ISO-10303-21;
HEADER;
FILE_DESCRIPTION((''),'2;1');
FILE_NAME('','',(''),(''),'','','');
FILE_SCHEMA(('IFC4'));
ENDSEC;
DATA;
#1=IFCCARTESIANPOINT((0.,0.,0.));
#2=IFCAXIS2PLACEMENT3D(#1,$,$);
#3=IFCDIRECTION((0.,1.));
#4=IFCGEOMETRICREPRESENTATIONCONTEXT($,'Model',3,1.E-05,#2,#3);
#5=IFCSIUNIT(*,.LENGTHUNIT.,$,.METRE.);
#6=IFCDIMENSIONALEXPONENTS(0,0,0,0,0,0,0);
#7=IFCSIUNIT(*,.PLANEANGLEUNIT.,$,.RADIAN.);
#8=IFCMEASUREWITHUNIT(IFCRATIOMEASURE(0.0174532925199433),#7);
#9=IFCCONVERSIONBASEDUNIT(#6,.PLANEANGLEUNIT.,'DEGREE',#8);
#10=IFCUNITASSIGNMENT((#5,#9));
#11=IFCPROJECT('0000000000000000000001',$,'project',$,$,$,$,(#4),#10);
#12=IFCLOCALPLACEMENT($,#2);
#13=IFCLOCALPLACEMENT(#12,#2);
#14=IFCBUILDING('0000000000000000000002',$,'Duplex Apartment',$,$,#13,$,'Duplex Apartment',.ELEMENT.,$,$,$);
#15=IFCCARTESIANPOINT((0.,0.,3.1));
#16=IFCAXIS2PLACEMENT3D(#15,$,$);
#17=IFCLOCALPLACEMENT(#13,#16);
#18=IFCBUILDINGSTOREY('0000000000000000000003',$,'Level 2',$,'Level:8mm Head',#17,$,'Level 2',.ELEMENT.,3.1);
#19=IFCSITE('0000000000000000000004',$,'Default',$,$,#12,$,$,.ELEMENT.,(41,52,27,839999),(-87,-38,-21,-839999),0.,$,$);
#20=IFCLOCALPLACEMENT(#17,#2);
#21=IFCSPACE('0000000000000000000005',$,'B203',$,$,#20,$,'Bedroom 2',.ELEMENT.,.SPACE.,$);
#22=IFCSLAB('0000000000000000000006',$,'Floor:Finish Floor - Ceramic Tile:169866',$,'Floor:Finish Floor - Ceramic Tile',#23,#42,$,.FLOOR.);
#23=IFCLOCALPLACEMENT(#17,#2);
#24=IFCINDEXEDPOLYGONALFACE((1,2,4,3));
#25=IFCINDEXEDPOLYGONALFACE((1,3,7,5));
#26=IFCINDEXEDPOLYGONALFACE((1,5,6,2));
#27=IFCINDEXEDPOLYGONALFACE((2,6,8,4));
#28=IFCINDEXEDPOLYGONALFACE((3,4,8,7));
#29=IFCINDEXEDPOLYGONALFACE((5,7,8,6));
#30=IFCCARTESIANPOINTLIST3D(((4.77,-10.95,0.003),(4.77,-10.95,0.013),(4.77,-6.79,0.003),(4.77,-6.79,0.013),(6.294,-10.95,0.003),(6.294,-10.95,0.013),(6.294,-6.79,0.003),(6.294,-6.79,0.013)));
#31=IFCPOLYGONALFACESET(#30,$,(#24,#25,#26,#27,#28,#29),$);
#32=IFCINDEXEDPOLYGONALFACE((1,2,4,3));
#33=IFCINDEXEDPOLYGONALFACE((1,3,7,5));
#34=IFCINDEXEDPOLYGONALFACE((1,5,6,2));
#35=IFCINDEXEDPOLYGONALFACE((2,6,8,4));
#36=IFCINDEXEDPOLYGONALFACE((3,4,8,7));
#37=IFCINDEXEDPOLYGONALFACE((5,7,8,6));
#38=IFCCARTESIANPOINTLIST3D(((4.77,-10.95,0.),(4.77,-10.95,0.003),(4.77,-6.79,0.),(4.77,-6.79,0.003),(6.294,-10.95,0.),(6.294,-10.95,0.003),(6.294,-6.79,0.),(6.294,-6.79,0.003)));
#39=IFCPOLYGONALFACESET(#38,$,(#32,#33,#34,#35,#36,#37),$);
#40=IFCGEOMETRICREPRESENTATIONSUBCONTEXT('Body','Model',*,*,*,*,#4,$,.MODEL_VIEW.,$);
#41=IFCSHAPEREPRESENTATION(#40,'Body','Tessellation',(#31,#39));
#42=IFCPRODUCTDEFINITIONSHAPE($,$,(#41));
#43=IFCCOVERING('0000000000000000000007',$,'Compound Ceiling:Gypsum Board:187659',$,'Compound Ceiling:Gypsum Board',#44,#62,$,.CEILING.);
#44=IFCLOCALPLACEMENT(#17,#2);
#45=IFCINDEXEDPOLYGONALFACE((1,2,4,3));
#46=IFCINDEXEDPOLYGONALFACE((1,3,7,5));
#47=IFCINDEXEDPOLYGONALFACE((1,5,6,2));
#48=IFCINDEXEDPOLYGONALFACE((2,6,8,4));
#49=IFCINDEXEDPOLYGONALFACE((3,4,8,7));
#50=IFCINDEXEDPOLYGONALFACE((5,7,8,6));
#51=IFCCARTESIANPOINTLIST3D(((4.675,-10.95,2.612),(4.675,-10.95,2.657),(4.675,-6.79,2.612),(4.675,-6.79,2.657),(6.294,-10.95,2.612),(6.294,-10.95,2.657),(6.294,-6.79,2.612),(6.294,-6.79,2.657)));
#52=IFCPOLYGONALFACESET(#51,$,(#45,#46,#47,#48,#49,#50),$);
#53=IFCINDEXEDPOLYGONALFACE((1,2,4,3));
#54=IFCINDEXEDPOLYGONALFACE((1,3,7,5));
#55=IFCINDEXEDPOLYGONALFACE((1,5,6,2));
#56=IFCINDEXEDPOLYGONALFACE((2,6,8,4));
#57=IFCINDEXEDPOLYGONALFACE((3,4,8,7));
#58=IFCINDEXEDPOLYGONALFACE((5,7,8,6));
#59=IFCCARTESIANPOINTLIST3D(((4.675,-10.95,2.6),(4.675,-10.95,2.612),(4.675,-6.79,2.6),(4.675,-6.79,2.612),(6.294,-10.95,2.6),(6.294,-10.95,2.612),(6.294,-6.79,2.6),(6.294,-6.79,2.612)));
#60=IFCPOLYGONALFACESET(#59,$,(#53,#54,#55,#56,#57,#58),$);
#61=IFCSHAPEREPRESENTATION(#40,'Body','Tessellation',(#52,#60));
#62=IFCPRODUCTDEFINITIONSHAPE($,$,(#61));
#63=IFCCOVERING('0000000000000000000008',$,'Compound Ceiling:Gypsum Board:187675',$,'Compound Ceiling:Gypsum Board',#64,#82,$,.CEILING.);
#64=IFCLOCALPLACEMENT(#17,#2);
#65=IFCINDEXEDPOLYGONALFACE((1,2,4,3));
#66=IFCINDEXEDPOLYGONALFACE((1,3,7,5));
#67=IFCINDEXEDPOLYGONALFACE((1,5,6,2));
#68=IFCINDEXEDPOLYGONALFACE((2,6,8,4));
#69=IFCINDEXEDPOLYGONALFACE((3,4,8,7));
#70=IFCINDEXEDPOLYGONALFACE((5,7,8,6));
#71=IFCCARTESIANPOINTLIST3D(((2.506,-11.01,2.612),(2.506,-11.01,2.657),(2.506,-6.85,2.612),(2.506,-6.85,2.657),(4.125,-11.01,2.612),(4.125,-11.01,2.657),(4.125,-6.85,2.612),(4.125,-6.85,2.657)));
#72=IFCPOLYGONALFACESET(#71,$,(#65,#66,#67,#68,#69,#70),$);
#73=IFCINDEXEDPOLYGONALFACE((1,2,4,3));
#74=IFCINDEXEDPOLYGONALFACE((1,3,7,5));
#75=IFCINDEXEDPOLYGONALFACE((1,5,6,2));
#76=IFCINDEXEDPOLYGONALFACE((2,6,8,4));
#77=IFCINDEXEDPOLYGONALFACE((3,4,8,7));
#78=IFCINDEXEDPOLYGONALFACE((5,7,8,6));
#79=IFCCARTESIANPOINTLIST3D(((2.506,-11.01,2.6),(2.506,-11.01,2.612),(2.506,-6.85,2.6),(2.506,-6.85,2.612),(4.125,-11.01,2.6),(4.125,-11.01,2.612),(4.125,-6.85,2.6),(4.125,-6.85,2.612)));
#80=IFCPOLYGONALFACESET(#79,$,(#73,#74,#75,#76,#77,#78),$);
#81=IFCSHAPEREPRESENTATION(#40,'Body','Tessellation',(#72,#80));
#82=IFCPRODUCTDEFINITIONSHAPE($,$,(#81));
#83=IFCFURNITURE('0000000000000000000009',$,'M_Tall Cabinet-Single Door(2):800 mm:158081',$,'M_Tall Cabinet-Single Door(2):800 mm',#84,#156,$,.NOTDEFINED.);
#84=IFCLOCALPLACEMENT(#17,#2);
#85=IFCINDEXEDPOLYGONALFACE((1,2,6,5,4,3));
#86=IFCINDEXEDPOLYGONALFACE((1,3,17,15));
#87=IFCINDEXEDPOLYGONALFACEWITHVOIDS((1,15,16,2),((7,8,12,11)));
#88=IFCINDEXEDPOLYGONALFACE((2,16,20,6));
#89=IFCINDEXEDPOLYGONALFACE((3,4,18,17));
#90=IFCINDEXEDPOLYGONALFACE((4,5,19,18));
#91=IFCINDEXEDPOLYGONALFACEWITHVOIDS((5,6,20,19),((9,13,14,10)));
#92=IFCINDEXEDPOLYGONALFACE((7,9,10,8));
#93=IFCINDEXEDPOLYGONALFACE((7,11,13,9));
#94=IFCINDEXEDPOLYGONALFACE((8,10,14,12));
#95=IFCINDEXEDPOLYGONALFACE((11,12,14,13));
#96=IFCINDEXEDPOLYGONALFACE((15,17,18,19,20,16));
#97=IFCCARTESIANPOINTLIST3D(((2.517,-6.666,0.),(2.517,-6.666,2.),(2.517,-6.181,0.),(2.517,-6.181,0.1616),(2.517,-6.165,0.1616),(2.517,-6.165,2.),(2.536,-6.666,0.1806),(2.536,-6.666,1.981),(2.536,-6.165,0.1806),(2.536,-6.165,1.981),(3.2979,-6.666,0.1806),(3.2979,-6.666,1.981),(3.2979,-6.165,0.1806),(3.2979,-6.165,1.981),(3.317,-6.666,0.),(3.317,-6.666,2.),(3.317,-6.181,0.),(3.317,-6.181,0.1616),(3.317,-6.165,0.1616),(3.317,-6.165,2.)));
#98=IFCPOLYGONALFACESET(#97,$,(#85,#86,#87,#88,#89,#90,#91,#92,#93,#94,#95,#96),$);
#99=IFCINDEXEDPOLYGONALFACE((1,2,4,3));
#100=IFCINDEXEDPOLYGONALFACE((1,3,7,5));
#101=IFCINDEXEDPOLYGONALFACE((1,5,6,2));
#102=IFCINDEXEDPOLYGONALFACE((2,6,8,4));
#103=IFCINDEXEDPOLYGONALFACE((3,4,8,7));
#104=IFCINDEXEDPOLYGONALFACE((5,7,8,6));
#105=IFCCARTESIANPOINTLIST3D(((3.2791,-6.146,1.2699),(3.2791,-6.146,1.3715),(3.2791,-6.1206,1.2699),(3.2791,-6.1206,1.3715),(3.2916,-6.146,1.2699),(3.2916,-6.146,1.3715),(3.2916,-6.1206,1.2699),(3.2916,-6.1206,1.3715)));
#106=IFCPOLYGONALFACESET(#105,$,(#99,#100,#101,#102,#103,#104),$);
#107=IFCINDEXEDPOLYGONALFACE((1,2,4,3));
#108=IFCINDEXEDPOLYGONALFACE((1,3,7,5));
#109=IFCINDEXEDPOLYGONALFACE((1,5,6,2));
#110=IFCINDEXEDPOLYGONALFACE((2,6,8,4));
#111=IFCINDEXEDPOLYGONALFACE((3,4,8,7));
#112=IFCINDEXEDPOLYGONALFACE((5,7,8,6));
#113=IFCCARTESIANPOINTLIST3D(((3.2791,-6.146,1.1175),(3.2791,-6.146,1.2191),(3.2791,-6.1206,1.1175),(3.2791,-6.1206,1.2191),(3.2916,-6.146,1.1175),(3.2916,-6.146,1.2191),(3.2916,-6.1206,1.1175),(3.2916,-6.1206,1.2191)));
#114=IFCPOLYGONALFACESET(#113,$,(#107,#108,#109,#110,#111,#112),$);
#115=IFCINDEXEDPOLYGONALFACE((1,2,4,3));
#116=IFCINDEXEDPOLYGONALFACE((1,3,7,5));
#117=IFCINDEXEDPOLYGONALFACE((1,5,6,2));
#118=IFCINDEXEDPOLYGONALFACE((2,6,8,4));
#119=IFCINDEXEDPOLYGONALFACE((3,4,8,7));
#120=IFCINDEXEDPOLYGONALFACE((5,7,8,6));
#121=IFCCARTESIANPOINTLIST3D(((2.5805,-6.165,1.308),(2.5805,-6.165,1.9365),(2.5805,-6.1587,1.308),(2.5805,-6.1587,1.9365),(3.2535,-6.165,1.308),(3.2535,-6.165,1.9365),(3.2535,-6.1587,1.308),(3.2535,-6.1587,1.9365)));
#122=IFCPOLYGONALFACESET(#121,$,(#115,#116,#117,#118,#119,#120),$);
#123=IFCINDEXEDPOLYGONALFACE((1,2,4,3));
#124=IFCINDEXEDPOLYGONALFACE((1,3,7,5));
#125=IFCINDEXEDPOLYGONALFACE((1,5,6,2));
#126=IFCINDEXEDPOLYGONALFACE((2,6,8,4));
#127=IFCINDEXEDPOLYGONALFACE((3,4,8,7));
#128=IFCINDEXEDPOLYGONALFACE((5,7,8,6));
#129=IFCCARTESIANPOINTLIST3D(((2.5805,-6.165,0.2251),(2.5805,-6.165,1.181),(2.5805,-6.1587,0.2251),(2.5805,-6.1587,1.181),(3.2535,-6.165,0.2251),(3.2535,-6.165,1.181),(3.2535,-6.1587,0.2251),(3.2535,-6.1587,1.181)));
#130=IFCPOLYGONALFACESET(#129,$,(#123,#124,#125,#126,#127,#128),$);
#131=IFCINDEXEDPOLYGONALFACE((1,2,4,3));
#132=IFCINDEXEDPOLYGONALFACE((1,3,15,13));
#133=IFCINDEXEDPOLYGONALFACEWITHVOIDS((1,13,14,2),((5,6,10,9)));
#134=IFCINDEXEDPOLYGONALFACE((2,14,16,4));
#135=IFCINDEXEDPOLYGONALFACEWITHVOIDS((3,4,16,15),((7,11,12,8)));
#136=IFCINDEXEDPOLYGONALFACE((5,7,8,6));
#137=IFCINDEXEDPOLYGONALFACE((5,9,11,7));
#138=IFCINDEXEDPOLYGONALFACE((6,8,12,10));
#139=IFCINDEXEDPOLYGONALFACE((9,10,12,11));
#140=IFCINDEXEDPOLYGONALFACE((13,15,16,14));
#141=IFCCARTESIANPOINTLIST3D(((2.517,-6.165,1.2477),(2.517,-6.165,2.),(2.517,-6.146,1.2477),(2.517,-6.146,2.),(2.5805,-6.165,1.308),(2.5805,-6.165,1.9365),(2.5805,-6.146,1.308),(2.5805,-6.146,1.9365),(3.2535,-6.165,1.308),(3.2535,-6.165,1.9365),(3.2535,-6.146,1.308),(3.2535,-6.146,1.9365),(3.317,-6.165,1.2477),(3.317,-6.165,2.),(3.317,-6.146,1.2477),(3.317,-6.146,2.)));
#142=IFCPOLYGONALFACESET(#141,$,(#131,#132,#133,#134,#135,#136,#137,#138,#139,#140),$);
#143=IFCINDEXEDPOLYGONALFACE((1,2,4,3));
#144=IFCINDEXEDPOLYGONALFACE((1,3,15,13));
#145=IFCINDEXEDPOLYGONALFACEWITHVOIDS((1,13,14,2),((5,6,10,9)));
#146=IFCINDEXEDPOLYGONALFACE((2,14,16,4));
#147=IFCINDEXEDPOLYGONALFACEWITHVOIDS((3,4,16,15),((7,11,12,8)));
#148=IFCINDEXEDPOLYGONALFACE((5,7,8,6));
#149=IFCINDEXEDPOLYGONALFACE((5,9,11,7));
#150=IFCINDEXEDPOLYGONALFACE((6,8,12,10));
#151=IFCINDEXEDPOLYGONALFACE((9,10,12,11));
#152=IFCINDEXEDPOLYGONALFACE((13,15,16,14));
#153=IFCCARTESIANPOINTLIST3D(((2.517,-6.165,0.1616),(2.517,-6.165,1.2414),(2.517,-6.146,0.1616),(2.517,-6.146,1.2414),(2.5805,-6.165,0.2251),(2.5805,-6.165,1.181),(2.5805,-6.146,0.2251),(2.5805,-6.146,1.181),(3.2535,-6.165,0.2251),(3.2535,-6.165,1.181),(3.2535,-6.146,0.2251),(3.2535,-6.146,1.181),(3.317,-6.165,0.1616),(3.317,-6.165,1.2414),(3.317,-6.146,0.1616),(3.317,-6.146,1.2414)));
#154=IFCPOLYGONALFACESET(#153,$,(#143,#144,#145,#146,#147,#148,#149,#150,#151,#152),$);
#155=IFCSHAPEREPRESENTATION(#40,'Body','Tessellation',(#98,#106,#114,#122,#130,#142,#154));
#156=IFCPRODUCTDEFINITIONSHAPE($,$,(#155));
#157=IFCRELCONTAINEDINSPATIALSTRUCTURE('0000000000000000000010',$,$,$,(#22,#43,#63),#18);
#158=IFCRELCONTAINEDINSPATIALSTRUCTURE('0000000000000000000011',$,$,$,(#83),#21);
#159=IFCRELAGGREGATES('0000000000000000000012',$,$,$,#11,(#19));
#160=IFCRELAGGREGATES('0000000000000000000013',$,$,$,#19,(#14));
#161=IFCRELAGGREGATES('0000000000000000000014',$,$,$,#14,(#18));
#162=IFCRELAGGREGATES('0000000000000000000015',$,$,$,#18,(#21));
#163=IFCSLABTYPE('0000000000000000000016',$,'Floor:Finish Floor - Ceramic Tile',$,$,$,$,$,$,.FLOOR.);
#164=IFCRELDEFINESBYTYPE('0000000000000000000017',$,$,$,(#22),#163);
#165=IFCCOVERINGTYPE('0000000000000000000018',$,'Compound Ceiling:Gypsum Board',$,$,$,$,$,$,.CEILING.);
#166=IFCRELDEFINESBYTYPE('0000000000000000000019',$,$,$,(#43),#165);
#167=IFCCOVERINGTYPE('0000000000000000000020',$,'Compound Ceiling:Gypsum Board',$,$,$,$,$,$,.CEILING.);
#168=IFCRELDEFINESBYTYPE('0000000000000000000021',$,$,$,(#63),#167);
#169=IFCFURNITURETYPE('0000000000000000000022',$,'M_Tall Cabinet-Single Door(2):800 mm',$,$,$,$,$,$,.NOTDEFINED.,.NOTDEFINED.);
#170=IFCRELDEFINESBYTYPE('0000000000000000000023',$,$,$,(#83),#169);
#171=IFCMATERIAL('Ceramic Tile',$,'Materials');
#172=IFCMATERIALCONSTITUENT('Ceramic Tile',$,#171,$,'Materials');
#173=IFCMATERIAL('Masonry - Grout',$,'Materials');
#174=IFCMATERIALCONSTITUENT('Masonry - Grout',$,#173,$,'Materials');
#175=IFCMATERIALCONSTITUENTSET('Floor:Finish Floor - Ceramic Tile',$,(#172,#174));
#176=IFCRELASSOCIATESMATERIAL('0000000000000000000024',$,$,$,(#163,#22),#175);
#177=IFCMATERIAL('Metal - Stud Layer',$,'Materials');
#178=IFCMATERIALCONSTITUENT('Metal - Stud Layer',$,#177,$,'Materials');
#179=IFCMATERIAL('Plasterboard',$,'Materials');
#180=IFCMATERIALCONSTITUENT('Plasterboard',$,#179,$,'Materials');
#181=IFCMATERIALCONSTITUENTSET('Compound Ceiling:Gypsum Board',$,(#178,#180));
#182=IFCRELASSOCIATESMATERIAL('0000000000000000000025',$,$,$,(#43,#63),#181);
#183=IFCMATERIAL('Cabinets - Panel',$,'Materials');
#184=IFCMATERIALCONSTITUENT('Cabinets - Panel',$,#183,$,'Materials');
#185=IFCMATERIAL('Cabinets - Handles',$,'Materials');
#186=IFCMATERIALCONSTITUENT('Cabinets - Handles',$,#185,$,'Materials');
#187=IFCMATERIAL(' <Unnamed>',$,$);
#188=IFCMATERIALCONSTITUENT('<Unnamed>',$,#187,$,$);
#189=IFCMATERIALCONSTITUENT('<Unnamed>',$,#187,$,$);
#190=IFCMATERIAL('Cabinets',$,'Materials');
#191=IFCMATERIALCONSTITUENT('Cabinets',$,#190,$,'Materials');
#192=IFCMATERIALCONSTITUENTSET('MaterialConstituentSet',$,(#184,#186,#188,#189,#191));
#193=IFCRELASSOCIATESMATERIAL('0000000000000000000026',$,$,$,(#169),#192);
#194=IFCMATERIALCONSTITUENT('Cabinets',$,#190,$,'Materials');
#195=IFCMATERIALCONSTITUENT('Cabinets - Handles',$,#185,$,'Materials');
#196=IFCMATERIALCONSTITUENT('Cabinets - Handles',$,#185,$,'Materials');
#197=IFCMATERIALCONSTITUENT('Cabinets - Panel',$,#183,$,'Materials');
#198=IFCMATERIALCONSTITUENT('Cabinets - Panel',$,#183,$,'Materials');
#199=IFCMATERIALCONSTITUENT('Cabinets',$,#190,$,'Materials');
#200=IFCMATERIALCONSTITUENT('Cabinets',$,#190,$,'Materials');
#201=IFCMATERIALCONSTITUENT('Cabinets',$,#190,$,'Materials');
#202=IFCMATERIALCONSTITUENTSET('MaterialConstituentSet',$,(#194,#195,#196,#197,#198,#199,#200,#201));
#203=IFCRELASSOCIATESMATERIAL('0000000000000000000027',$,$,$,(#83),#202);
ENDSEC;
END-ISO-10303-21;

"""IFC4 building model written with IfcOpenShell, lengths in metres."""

from ifc_helpers import new_model, entity, si_unit, converted_unit, direction, frame, origin, place, context, subcontext, project, spatial, indexed_curve, outline, extrude, source, transform, mapped, material, constituent, constituent_set, type_object, type_shapes, element, save


model = new_model("IFC4")

# Units and contexts
model_context = context("Model", 3, precision=1e-05, world=origin(), true_north=direction((0.0, 1.0)))
body_context = subcontext(model_context, "Body", "Model", "MODEL_VIEW")
ifc_project = project(units=[si_unit("LENGTHUNIT", "METRE"), converted_unit("PLANEANGLEUNIT", "DEGREE", entity("IfcRatioMeasure", 0.0174532925199433), si_unit("PLANEANGLEUNIT", "RADIAN"), dimensions=[0, 0, 0, 0, 0, 0, 0])], contexts=[model_context])

# Site, building, storey
site_placement = place(None, origin())
site = spatial("IfcSite", under=ifc_project, at=site_placement, Name="Default", CompositionType="ELEMENT", RefLatitude=(41, 52, 27, 839999), RefLongitude=(-87, -38, -21, -839999), RefElevation=0.0)
building_placement = place(site_placement, origin())
building = spatial("IfcBuilding", under=site, at=building_placement, Name="Duplex Apartment", LongName="Duplex Apartment", CompositionType="ELEMENT")
storey_placement = place(building_placement, frame((0.0, 0.0, 3.1)))
storey = spatial("IfcBuildingStorey", under=building, at=storey_placement, Name="Level 2", ObjectType="Level:8mm Head", LongName="Level 2", CompositionType="ELEMENT", Elevation=3.1)

# Slab
ifc_material_1 = material(Name="Ceramic Tile", Category="Materials")
ifc_constituent_1 = constituent(ifc_material_1, Name="Ceramic Tile", Category="Materials")
ifc_material_2 = material(Name="Masonry - Grout", Category="Materials")
ifc_constituent_2 = constituent(ifc_material_2, Name="Masonry - Grout", Category="Materials")
ifc_constituent_set_1 = constituent_set(constituents=[ifc_constituent_1, ifc_constituent_2], Name="Floor:Finish Floor - Ceramic Tile")
slab_type_1 = type_object("IfcSlabType", Name="Floor:Finish Floor - Ceramic Tile", PredefinedType="FLOOR", material=ifc_constituent_set_1)
slab_1_placement = place(storey_placement, origin())
element("IfcSlab", 1, at=slab_1_placement, inside=storey, type_object=slab_type_1, material=ifc_constituent_set_1, Name="Floor:Finish Floor - Ceramic Tile:169866", ObjectType="Floor:Finish Floor - Ceramic Tile", PredefinedType="FLOOR", context=body_context, shape_type="SweptSolid", body=[
    extrude(outline(indexed_curve([(-0.762, -2.08), (0.762, -2.08), (0.762, 2.08), (-0.762, 2.08), (-0.762, -2.08)], self_intersect=False)), frame((5.532, -8.87, 0.003), z_axis=(0.0, 0.0, 1.0), x_axis=(-1.0, 0.0, 0.0)), (0.0, 0.0, 1.0), 0.01),
    extrude(outline(indexed_curve([(-0.762, -2.08), (0.762, -2.08), (0.762, 2.08), (-0.762, 2.08), (-0.762, -2.08)], self_intersect=False)), frame((5.532, -8.87, 0.0), z_axis=(0.0, 0.0, 1.0), x_axis=(-1.0, 0.0, 0.0)), (0.0, 0.0, 1.0), 0.003),
])

# Shared definitions
ifc_material_3 = material(Name="Plasterboard", Category="Materials")
ifc_material_4 = material(Name="Metal - Stud Layer", Category="Materials")

# Shared definitions
space_1_placement = place(storey_placement, origin())
space_1 = spatial("IfcSpace", under=storey, at=space_1_placement, Name="B203", LongName="Bedroom 2", CompositionType="ELEMENT", PredefinedType="SPACE")

# Shared definitions
ifc_constituent_3 = constituent(ifc_material_4, Name="Metal - Stud Layer", Category="Materials")
ifc_constituent_4 = constituent(ifc_material_3, Name="Plasterboard", Category="Materials")
ifc_constituent_set_2 = constituent_set(constituents=[ifc_constituent_3, ifc_constituent_4], Name="Compound Ceiling:Gypsum Board")

# Coverings
covering_type_1 = type_object("IfcCoveringType", Name="Compound Ceiling:Gypsum Board", PredefinedType="CEILING")
covering_1_placement = place(storey_placement, origin())
element("IfcCovering", 2, at=covering_1_placement, inside=storey, type_object=covering_type_1, material=ifc_constituent_set_2, Name="Compound Ceiling:Gypsum Board:187659", ObjectType="Compound Ceiling:Gypsum Board", PredefinedType="CEILING", context=body_context, shape_type="SweptSolid", body=[
    extrude(outline(indexed_curve([(-2.08, -0.8095), (2.08, -0.8095), (2.08, 0.8095), (-2.08, 0.8095), (-2.08, -0.8095)], self_intersect=False)), frame((5.4845, -8.87, 2.612), z_axis=(0.0, 0.0, 1.0), x_axis=(0.0, 1.0, 0.0)), (0.0, 0.0, 1.0), 0.045),
    extrude(outline(indexed_curve([(-0.8095, -2.08), (0.8095, -2.08), (0.8095, 2.08), (-0.8095, 2.08), (-0.8095, -2.08)], self_intersect=False)), frame((5.4845, -8.87, 2.6)), (0.0, 0.0, 1.0), 0.012),
])
covering_type_2 = type_object("IfcCoveringType", Name="Compound Ceiling:Gypsum Board", PredefinedType="CEILING")
covering_2_placement = place(storey_placement, origin())
element("IfcCovering", 3, at=covering_2_placement, inside=storey, type_object=covering_type_2, material=ifc_constituent_set_2, Name="Compound Ceiling:Gypsum Board:187675", ObjectType="Compound Ceiling:Gypsum Board", PredefinedType="CEILING", context=body_context, shape_type="SweptSolid", body=[
    extrude(outline(indexed_curve([(-2.08, -0.8095), (2.08, -0.8095), (2.08, 0.8095), (-2.08, 0.8095), (-2.08, -0.8095)], self_intersect=False)), frame((3.3155, -8.93, 2.612), z_axis=(0.0, 0.0, 1.0), x_axis=(0.0, -1.0, 0.0)), (0.0, 0.0, 1.0), 0.045),
    extrude(outline(indexed_curve([(-0.8095, -2.08), (0.8095, -2.08), (0.8095, 2.08), (-0.8095, 2.08), (-0.8095, -2.08)], self_intersect=False)), frame((3.3155, -8.93, 2.6), z_axis=(0.0, 0.0, 1.0), x_axis=(-1.0, 0.0, 0.0)), (0.0, 0.0, 1.0), 0.012),
])

# Furniture, opening
ifc_material_5 = material(Name="Cabinets", Category="Materials")
ifc_constituent_5 = constituent(ifc_material_5, Name="Cabinets", Category="Materials")
ifc_material_6 = material(Name="Cabinets - Handles", Category="Materials")
ifc_constituent_6 = constituent(ifc_material_6, Name="Cabinets - Handles", Category="Materials")
ifc_constituent_7 = constituent(ifc_material_6, Name="Cabinets - Handles", Category="Materials")
ifc_material_7 = material(Name="Cabinets - Panel", Category="Materials")
ifc_constituent_8 = constituent(ifc_material_7, Name="Cabinets - Panel", Category="Materials")
ifc_constituent_9 = constituent(ifc_material_7, Name="Cabinets - Panel", Category="Materials")
ifc_constituent_10 = constituent(ifc_material_5, Name="Cabinets", Category="Materials")
ifc_constituent_11 = constituent(ifc_material_5, Name="Cabinets", Category="Materials")
ifc_constituent_12 = constituent(ifc_material_5, Name="Cabinets", Category="Materials")
ifc_constituent_set_3 = constituent_set(constituents=[ifc_constituent_5, ifc_constituent_6, ifc_constituent_7, ifc_constituent_8, ifc_constituent_9, ifc_constituent_10, ifc_constituent_11, ifc_constituent_12], Name="MaterialConstituentSet")
ifc_constituent_13 = constituent(ifc_material_7, Name="Cabinets - Panel", Category="Materials")
ifc_constituent_14 = constituent(ifc_material_6, Name="Cabinets - Handles", Category="Materials")
ifc_material_8 = material(Name=" <Unnamed>")
ifc_constituent_15 = constituent(ifc_material_8, Name="<Unnamed>")
ifc_constituent_16 = constituent(ifc_material_8, Name="<Unnamed>")
ifc_constituent_17 = constituent(ifc_material_5, Name="Cabinets", Category="Materials")
ifc_constituent_set_4 = constituent_set(constituents=[ifc_constituent_13, ifc_constituent_14, ifc_constituent_15, ifc_constituent_16, ifc_constituent_17], Name="MaterialConstituentSet")
furniture_type_1 = type_object("IfcFurnitureType", Name="M_Tall Cabinet-Single Door(2):800 mm", AssemblyPlace="NOTDEFINED", PredefinedType="NOTDEFINED", material=ifc_constituent_set_4)
shared_shape_1 = source(origin(), body_context, "Body", "SweptSolid", [
    extrude(outline(indexed_curve([(-0.5589, -0.1723), (1.2795, -0.1723), (1.2795, 0.3286), (-0.7205, 0.3286), (-0.7205, -0.1563), (-0.5589, -0.1563), (-0.5589, -0.1723)], self_intersect=False)), frame((-0.3813, 0.3286, 0.7205), z_axis=(1.0, 0.0, 0.0), x_axis=(0.0, 0.0, 1.0)), (0.0, 0.0, 1.0), 0.8),
    extrude(outline(indexed_curve([(-0.0063, -0.0127), (0.0063, -0.0127), (0.0063, 0.0127), (-0.0063, 0.0127), (-0.0063, -0.0127)], self_intersect=False)), frame((0.3871, 0.5327, 1.2699), z_axis=(0.0, 0.0, 1.0), x_axis=(-1.0, 0.0, 0.0)), (0.0, 0.0, 1.0), 0.1016),
    extrude(outline(indexed_curve([(-0.0063, -0.0127), (0.0063, -0.0127), (0.0063, 0.0127), (-0.0063, 0.0127), (-0.0063, -0.0127)], self_intersect=False)), frame((0.3871, 0.5327, 1.1175), z_axis=(0.0, 0.0, 1.0), x_axis=(-1.0, 0.0, 0.0)), (0.0, 0.0, 1.0), 0.1016),
    extrude(outline(indexed_curve([(-0.3365, -0.0032), (0.3365, -0.0032), (0.3365, 0.0032), (-0.3365, 0.0032), (-0.3365, -0.0032)], self_intersect=False)), frame((0.0187, 0.5041, 1.308), z_axis=(0.0, 0.0, 1.0), x_axis=(-1.0, 0.0, 0.0)), (0.0, 0.0, 1.0), 0.6285),
    extrude(outline(indexed_curve([(-0.3365, -0.0032), (0.3365, -0.0032), (0.3365, 0.0032), (-0.3365, 0.0032), (-0.3365, -0.0032)], self_intersect=False)), frame((0.0187, 0.5041, 0.2251), z_axis=(0.0, 0.0, 1.0), x_axis=(-1.0, 0.0, 0.0)), (0.0, 0.0, 1.0), 0.956),
    extrude(outline(indexed_curve([(-0.3761, -0.4), (0.3761, -0.4), (0.3761, 0.4), (-0.3761, 0.4), (-0.3761, -0.4)], self_intersect=False), holes=[indexed_curve([(-0.3126, -0.3365), (-0.3126, 0.3365), (0.3158, 0.3365), (0.3158, -0.3365), (-0.3126, -0.3365)], self_intersect=False)]), frame((0.0187, 0.501, 1.6239), z_axis=(0.0, 1.0, 0.0), x_axis=(0.0, 0.0, -1.0)), (0.0, 0.0, 1.0), 0.0191),
    extrude(outline(indexed_curve([(-0.4, -0.5399), (0.4, -0.5399), (0.4, 0.5399), (-0.4, 0.5399), (-0.4, -0.5399)], self_intersect=False), holes=[indexed_curve([(-0.3365, 0.4796), (0.3365, 0.4796), (0.3365, -0.4764), (-0.3365, -0.4764), (-0.3365, 0.4796)], self_intersect=False)]), frame((0.0187, 0.501, 0.7015), z_axis=(0.0, 1.0, 0.0), x_axis=(-1.0, 0.0, 0.0)), (0.0, 0.0, 1.0), 0.0191),
    extrude(outline(indexed_curve([(-0.381, -0.0095), (0.381, -0.0095), (0.381, 0.0095), (-0.381, 0.0095), (-0.381, -0.0095)], self_intersect=False)), frame((0.0187, 0.0095, 0.1806), z_axis=(0.0, 0.0, 1.0), x_axis=(-1.0, 0.0, 0.0)), (0.0, 0.0, 1.0), 1.8003),
])
type_shapes(furniture_type_1, [shared_shape_1])
furniture_1_placement = place(space_1_placement, frame((2.8983, -6.666, 0.0)))
furniture_1 = element("IfcFurniture", 4, at=furniture_1_placement, inside=space_1, type_object=furniture_type_1, material=ifc_constituent_set_3, Name="M_Tall Cabinet-Single Door(2):800 mm:158081", ObjectType="M_Tall Cabinet-Single Door(2):800 mm", PredefinedType="NOTDEFINED", context=body_context, shape_type="MappedRepresentation", body=[
    mapped(shared_shape_1, transform((0.0, 0.0, 0.0), scale=1.0)),
])
opening_1_placement = place(storey_placement, frame((2.8983, -6.666, 3.1)))
element("IfcOpeningElement", 5, at=opening_1_placement, cuts=furniture_1, ObjectType="Opening", PredefinedType="OPENING", context=body_context, shape_type="SweptSolid", body=[
    extrude(outline(indexed_curve([(-0.9002, -0.381), (0.9002, -0.381), (0.9002, 0.381), (-0.9002, 0.381), (-0.9002, -0.381)], self_intersect=False)), frame((0.0187, 0.0, -2.0192), z_axis=(0.0, 1.0, 0.0), x_axis=(0.0, 0.0, -1.0)), (0.0, 0.0, 1.0), 0.501),
])

save(model, "model.ifc")
